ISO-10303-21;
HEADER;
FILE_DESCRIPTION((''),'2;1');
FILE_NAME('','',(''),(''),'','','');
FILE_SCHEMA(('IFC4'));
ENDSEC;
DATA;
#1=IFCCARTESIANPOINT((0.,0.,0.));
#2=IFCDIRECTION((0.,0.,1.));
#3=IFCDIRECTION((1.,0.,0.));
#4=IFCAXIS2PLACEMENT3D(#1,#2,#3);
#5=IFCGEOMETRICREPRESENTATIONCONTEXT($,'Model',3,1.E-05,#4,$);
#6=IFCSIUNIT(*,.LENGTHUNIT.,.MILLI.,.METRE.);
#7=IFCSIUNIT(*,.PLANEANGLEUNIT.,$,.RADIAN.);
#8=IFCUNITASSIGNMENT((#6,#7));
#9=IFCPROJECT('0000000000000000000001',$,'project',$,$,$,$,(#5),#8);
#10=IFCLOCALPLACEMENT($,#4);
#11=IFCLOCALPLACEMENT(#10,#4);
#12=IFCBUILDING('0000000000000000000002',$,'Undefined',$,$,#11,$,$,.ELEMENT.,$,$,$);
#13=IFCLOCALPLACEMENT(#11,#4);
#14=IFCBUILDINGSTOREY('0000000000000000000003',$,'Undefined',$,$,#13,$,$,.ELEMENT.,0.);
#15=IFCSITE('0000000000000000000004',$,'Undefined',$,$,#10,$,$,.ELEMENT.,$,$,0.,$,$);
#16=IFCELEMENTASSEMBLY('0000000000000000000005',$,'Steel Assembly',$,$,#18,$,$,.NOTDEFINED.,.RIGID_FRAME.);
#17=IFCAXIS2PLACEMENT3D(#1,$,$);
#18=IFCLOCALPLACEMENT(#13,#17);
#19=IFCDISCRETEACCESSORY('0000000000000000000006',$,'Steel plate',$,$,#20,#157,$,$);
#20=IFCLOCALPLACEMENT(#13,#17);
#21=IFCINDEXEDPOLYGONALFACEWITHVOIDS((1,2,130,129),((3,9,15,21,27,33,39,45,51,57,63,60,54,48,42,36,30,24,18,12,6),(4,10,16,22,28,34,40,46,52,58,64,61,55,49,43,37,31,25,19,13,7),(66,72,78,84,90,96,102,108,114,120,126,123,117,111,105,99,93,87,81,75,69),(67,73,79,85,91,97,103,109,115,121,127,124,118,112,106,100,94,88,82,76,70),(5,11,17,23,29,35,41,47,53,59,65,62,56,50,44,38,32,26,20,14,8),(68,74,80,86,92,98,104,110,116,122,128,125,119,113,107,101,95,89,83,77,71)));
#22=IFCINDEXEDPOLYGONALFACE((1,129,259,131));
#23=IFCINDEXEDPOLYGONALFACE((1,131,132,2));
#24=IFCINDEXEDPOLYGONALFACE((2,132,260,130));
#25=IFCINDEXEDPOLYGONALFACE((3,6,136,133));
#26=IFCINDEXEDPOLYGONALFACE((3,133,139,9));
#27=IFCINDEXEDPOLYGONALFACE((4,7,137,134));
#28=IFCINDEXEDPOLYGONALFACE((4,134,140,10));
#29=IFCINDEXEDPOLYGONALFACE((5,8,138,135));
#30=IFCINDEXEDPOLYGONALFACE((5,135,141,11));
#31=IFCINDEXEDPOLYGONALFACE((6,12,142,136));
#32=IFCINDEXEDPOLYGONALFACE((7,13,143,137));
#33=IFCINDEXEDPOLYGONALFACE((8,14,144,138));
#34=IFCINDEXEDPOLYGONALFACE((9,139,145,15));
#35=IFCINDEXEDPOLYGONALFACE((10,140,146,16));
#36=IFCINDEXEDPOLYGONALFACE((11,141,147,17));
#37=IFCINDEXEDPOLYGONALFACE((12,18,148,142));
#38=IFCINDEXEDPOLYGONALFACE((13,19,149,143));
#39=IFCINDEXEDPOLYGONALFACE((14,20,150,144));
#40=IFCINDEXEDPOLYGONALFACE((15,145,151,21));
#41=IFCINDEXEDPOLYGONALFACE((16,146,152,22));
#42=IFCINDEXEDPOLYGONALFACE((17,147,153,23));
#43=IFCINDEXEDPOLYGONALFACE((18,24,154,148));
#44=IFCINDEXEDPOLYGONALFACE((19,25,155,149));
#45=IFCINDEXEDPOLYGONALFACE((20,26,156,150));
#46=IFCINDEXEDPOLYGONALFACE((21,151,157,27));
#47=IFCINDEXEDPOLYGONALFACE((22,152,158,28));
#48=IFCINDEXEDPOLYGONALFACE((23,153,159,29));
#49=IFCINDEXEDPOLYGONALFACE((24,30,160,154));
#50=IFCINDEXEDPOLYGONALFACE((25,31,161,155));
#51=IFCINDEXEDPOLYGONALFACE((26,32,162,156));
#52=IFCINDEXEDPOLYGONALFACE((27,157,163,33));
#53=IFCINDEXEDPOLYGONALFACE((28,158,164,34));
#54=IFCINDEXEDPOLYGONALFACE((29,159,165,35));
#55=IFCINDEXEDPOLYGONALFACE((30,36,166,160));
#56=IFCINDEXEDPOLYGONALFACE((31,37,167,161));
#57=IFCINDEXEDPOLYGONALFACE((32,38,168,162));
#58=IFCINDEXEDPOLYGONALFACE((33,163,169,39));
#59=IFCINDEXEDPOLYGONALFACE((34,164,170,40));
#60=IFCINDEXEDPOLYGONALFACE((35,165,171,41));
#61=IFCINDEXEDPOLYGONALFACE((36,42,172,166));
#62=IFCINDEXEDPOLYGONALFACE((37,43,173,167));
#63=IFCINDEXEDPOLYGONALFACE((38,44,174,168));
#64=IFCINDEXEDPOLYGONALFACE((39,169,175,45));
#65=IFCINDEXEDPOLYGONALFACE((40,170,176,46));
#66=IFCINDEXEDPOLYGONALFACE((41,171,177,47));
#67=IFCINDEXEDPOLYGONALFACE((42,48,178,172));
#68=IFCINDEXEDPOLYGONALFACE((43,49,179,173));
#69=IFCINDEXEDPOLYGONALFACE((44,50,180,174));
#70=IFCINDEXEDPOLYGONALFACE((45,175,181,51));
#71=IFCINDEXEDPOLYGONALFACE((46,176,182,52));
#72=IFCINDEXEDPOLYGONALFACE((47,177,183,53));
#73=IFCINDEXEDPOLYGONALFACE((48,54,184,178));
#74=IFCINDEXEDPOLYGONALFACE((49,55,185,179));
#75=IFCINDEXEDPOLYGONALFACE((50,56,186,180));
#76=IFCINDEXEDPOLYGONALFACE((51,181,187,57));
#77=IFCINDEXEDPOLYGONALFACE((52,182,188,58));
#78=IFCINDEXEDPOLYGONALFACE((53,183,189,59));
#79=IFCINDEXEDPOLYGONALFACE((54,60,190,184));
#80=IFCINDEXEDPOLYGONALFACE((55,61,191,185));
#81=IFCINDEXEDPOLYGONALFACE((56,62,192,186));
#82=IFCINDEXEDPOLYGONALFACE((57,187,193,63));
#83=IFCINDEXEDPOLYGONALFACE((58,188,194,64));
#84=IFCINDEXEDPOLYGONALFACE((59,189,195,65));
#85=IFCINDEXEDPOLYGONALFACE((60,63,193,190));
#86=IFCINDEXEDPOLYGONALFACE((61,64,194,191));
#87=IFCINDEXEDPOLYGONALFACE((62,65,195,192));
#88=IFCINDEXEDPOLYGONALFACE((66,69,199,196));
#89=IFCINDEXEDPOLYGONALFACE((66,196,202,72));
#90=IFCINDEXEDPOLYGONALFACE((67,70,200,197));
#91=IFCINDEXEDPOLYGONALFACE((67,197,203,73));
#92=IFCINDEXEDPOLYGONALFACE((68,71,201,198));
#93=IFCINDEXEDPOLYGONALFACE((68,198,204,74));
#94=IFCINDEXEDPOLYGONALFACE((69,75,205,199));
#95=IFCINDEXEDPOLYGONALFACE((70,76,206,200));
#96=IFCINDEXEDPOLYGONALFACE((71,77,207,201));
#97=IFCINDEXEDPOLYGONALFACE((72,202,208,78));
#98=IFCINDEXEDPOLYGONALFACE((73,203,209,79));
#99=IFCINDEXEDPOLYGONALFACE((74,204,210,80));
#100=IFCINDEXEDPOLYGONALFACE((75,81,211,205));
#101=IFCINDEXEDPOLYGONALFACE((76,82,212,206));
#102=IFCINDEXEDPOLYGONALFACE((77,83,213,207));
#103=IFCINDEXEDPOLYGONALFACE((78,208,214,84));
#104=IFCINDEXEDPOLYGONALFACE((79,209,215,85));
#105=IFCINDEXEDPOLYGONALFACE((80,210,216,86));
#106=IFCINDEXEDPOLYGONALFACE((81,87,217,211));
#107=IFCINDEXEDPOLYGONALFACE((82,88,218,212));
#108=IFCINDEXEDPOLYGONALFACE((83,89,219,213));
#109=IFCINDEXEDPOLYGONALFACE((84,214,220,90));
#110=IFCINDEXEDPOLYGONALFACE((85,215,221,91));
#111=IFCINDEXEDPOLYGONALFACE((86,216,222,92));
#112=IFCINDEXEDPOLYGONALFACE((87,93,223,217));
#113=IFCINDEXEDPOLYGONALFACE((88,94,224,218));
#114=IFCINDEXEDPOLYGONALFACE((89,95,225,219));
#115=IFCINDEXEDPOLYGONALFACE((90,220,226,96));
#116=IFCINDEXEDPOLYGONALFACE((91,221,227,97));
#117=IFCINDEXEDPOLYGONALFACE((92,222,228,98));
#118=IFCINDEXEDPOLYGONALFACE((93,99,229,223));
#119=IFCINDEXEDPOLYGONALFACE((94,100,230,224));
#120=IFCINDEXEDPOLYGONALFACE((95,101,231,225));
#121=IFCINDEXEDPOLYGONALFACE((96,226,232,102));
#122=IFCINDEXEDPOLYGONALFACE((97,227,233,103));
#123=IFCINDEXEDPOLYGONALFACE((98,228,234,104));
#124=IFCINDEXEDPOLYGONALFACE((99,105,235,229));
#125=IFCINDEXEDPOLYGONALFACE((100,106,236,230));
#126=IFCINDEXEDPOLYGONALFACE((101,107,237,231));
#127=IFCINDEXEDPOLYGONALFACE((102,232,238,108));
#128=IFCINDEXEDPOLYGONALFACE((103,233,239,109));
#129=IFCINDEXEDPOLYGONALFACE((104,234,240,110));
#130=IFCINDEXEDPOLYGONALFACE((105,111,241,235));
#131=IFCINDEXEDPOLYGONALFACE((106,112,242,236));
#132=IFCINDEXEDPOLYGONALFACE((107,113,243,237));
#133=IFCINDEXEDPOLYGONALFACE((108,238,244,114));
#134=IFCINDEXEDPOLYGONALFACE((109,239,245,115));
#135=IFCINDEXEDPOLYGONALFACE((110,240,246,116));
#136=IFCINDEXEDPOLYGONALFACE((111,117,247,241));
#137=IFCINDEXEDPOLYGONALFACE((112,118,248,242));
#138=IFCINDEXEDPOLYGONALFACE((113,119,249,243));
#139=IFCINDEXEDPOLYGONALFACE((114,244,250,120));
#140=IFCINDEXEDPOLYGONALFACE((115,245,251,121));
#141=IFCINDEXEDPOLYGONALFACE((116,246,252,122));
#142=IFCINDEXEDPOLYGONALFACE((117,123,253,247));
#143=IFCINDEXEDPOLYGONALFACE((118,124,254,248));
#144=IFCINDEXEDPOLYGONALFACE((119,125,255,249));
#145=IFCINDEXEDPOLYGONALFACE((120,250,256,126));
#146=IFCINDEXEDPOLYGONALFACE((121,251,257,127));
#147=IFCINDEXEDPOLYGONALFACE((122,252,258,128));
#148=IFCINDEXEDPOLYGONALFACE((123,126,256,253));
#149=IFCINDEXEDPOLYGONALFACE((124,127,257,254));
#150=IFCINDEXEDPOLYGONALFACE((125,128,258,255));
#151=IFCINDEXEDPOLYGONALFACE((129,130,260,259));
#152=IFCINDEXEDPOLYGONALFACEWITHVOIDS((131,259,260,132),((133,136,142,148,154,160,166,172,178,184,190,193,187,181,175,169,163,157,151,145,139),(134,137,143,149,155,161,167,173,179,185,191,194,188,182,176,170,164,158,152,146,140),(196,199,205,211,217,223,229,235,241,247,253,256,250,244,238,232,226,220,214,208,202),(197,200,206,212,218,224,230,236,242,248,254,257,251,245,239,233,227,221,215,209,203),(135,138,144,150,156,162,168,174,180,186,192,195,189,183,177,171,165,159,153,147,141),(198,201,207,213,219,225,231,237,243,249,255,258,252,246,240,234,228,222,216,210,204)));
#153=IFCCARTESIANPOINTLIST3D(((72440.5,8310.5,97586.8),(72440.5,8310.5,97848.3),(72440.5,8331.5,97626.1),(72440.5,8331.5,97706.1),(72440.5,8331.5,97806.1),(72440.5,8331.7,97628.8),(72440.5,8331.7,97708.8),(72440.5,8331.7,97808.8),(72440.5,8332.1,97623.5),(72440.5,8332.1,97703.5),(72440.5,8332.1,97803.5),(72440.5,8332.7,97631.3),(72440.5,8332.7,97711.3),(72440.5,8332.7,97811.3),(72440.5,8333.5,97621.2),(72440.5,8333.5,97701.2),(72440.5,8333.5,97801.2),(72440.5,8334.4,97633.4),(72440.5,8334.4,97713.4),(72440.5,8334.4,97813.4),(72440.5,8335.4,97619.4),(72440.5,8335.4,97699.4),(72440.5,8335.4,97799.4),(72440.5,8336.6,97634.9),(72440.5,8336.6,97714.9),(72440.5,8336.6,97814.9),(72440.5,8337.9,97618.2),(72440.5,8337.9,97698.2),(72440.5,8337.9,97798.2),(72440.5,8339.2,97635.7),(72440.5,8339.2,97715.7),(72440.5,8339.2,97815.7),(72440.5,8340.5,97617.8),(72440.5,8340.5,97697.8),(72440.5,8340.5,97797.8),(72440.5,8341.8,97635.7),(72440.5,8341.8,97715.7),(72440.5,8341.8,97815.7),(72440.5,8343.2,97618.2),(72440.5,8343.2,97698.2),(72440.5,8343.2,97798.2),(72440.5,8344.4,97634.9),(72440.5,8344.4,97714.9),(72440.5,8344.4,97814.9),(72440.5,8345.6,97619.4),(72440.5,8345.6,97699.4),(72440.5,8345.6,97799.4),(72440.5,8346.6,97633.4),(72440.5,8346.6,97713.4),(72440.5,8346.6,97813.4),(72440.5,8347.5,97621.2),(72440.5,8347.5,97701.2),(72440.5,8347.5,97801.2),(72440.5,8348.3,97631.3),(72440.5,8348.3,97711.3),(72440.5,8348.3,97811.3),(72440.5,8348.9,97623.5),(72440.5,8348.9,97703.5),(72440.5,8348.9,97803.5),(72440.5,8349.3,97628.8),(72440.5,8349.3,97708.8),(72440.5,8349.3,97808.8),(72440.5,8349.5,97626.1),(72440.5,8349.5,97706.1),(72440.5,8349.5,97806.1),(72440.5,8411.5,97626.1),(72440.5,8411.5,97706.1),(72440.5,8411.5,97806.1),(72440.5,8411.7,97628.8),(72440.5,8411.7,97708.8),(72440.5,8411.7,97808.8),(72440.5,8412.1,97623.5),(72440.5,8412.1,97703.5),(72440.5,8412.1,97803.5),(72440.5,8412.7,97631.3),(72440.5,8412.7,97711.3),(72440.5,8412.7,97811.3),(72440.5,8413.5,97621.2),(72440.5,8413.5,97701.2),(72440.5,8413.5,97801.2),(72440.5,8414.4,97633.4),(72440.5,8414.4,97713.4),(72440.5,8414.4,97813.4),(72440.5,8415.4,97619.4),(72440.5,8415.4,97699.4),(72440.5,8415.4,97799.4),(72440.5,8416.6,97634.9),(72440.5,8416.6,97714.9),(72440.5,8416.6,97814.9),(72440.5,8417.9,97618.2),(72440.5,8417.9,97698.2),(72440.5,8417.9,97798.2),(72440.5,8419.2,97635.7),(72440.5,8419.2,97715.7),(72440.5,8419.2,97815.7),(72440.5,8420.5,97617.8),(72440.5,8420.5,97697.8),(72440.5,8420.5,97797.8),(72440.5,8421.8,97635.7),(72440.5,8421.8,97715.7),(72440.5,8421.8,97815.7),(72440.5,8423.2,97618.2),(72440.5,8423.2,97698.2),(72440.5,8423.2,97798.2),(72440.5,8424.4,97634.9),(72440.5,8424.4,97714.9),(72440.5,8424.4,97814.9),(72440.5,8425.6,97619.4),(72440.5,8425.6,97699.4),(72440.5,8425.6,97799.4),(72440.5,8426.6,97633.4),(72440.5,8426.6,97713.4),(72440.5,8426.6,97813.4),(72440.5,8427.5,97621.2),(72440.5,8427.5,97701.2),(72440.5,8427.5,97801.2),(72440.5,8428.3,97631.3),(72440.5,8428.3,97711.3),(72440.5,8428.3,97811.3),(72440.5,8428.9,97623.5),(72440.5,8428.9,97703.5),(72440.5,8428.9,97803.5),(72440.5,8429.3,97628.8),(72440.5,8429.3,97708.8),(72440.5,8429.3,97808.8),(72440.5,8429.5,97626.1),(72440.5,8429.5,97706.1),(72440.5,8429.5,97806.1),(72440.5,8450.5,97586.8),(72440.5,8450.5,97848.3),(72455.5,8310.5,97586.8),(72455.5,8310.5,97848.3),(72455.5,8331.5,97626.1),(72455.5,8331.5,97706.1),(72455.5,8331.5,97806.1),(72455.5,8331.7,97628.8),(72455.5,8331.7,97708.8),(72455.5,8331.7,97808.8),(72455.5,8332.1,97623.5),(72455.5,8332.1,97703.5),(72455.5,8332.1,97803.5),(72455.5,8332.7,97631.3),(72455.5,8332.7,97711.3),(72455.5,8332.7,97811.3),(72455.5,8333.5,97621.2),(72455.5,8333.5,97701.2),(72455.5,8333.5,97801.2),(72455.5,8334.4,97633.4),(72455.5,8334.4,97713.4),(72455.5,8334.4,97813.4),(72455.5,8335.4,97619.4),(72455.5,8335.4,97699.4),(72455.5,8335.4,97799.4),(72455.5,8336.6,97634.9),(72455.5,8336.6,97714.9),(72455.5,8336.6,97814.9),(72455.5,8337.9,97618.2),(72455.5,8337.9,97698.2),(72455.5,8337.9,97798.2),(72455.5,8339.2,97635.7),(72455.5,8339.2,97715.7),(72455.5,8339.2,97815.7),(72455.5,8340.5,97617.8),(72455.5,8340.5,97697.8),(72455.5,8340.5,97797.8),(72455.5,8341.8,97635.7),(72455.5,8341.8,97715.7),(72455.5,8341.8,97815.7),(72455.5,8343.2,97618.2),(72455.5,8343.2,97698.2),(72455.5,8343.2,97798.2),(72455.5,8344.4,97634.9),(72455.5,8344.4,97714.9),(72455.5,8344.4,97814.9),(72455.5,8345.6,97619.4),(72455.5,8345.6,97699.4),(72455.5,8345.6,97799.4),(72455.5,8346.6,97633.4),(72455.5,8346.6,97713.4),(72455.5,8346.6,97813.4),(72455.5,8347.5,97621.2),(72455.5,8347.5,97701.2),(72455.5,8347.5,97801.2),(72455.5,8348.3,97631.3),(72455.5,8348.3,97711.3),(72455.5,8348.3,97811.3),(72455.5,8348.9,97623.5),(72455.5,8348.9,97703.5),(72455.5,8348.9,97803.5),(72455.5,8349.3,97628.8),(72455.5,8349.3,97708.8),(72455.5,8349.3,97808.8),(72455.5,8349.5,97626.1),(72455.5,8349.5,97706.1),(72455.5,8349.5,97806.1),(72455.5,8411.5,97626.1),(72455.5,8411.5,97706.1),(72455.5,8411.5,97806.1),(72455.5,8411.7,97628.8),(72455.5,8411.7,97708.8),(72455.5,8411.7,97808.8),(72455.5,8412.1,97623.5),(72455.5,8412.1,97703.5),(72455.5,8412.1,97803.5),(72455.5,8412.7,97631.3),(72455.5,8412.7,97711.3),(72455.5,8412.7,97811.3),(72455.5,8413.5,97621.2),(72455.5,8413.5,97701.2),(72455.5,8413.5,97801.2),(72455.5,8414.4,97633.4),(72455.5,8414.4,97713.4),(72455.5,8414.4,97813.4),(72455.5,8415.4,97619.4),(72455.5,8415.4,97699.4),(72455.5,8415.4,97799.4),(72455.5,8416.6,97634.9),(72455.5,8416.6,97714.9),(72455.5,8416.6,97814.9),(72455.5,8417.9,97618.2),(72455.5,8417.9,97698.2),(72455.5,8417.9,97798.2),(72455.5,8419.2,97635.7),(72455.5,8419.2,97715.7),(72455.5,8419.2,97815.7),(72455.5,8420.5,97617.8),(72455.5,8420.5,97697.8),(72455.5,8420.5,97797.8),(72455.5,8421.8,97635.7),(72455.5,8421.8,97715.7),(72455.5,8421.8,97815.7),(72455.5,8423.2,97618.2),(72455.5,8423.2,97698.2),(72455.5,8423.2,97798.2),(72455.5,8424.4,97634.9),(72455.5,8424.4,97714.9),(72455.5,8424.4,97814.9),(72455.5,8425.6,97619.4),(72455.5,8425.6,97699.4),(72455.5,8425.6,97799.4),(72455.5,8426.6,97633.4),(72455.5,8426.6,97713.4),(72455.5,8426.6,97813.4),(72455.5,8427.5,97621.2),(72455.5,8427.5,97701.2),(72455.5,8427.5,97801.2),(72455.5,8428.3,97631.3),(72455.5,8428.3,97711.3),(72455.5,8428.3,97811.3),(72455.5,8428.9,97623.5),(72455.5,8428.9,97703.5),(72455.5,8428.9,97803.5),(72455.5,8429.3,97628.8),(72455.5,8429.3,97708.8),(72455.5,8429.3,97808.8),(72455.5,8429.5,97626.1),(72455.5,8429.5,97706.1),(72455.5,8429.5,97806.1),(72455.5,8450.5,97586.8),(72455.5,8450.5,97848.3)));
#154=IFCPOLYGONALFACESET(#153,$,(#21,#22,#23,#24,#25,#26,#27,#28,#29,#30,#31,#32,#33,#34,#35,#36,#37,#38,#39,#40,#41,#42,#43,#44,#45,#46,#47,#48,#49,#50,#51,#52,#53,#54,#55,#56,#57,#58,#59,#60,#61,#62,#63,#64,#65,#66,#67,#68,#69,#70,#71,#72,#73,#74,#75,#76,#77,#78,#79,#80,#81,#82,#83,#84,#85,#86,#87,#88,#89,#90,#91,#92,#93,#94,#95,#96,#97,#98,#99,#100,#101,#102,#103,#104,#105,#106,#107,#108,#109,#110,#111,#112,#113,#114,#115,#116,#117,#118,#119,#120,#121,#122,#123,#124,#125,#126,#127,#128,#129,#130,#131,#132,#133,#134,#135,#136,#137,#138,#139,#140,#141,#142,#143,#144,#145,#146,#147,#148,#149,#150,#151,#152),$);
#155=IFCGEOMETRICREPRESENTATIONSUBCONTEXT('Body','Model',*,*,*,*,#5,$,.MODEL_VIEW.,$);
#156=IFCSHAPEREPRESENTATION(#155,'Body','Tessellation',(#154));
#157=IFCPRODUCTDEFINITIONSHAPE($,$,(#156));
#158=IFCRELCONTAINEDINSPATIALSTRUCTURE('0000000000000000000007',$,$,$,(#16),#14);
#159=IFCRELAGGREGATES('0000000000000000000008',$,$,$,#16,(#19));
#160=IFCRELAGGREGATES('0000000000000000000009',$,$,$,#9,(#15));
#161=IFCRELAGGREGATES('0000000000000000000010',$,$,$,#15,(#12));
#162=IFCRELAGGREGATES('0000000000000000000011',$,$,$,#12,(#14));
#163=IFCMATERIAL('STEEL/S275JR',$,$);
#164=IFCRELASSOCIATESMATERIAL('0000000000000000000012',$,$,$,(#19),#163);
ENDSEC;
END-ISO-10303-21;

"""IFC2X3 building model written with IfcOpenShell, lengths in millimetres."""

from ifc_helpers import new_model, si_unit, frame, origin_with_axes, origin_2d_with_axis, place, context, subcontext, project, spatial, polyline, circle, outline, extrude, source, transform, mapped, material, element, aggregate, save


model = new_model("IFC2X3")

# Units and contexts
model_context = context("Model", 3, precision=1e-05, world=origin_with_axes())
body_context = subcontext(model_context, "Body", "Model", "MODEL_VIEW")
ifc_project = project(units=[si_unit("LENGTHUNIT", "METRE", prefix="MILLI"), si_unit("PLANEANGLEUNIT", "RADIAN")], contexts=[model_context])

# Site, building, storey
site_placement = place(None, origin_with_axes())
site = spatial("IfcSite", under=ifc_project, at=site_placement, Name="Undefined", CompositionType="ELEMENT", RefElevation=0.0)
building_placement = place(site_placement, origin_with_axes())
building = spatial("IfcBuilding", under=site, at=building_placement, Name="Undefined", CompositionType="ELEMENT")
storey_placement = place(building_placement, origin_with_axes())
storey = spatial("IfcBuildingStorey", under=building, at=storey_placement, Name="Undefined", CompositionType="ELEMENT", Elevation=0.0)

# Shared definitions
ifc_material_1 = material(Name="STEEL/S275JR")

# Element assembly
assembly_1_placement = place(storey_placement, origin_with_axes())
assembly_1 = element("IfcElementAssembly", 1, at=assembly_1_placement, inside=storey, Name="Steel Assembly", AssemblyPlace="NOTDEFINED", PredefinedType="RIGID_FRAME")

# Shared definitions
shared_shape_1 = source(origin_with_axes(), body_context, "Body", "SweptSolid", [
    extrude(circle(Radius=9.0, at=origin_2d_with_axis()), frame((0.0, 0.9, 0.0), z_axis=(0.0, 1.0, 0.0), x_axis=(1.0, 0.0, 0.0)), (0.0, 0.0, 1.0), 16.1),
])

# Discrete accessory, opening
discrete_accessory_1_placement = place(assembly_1_placement, frame((72448.0, 8310.5, 97848.3), z_axis=(-1.0, 0.0, 0.0), x_axis=(0.0, 1.0, 0.0)))
discrete_accessory_1 = element("IfcDiscreteAccessory", 2, at=discrete_accessory_1_placement, material=ifc_material_1, Name="Steel plate", context=body_context, shape_type="SweptSolid", body=[
    extrude(outline(polyline([(0.0, 0.0), (140.0, 0.0), (140.0, 261.5), (0.0, 261.5), (0.0, 0.0)])), frame((0.0, 0.0, -7.5), z_axis=(0.0, 0.0, 1.0), x_axis=(1.0, 0.0, 0.0)), (0.0, 0.0, 1.0), 15.0),
])
opening_1_placement = place(assembly_1_placement, frame((72439.5, 8380.5, 97806.8), z_axis=(0.0, -1.0, 0.0), x_axis=(0.0, 0.0, -1.0)))
element("IfcOpeningElement", 3, at=opening_1_placement, cuts=discrete_accessory_1, ObjectType="Opening", context=body_context, shape_type="MappedRepresentation", body=[
    mapped(shared_shape_1, transform((0.0, 0.0, -40.0))),
    mapped(shared_shape_1, transform((100.0, 0.0, -40.0))),
    mapped(shared_shape_1, transform((180.0, 0.0, -40.0))),
    mapped(shared_shape_1, transform((0.0, 0.0, 40.0))),
    mapped(shared_shape_1, transform((100.0, 0.0, 40.0))),
    mapped(shared_shape_1, transform((180.0, 0.0, 40.0))),
])
aggregate(assembly_1, [discrete_accessory_1])

save(model, "model.ifc")
